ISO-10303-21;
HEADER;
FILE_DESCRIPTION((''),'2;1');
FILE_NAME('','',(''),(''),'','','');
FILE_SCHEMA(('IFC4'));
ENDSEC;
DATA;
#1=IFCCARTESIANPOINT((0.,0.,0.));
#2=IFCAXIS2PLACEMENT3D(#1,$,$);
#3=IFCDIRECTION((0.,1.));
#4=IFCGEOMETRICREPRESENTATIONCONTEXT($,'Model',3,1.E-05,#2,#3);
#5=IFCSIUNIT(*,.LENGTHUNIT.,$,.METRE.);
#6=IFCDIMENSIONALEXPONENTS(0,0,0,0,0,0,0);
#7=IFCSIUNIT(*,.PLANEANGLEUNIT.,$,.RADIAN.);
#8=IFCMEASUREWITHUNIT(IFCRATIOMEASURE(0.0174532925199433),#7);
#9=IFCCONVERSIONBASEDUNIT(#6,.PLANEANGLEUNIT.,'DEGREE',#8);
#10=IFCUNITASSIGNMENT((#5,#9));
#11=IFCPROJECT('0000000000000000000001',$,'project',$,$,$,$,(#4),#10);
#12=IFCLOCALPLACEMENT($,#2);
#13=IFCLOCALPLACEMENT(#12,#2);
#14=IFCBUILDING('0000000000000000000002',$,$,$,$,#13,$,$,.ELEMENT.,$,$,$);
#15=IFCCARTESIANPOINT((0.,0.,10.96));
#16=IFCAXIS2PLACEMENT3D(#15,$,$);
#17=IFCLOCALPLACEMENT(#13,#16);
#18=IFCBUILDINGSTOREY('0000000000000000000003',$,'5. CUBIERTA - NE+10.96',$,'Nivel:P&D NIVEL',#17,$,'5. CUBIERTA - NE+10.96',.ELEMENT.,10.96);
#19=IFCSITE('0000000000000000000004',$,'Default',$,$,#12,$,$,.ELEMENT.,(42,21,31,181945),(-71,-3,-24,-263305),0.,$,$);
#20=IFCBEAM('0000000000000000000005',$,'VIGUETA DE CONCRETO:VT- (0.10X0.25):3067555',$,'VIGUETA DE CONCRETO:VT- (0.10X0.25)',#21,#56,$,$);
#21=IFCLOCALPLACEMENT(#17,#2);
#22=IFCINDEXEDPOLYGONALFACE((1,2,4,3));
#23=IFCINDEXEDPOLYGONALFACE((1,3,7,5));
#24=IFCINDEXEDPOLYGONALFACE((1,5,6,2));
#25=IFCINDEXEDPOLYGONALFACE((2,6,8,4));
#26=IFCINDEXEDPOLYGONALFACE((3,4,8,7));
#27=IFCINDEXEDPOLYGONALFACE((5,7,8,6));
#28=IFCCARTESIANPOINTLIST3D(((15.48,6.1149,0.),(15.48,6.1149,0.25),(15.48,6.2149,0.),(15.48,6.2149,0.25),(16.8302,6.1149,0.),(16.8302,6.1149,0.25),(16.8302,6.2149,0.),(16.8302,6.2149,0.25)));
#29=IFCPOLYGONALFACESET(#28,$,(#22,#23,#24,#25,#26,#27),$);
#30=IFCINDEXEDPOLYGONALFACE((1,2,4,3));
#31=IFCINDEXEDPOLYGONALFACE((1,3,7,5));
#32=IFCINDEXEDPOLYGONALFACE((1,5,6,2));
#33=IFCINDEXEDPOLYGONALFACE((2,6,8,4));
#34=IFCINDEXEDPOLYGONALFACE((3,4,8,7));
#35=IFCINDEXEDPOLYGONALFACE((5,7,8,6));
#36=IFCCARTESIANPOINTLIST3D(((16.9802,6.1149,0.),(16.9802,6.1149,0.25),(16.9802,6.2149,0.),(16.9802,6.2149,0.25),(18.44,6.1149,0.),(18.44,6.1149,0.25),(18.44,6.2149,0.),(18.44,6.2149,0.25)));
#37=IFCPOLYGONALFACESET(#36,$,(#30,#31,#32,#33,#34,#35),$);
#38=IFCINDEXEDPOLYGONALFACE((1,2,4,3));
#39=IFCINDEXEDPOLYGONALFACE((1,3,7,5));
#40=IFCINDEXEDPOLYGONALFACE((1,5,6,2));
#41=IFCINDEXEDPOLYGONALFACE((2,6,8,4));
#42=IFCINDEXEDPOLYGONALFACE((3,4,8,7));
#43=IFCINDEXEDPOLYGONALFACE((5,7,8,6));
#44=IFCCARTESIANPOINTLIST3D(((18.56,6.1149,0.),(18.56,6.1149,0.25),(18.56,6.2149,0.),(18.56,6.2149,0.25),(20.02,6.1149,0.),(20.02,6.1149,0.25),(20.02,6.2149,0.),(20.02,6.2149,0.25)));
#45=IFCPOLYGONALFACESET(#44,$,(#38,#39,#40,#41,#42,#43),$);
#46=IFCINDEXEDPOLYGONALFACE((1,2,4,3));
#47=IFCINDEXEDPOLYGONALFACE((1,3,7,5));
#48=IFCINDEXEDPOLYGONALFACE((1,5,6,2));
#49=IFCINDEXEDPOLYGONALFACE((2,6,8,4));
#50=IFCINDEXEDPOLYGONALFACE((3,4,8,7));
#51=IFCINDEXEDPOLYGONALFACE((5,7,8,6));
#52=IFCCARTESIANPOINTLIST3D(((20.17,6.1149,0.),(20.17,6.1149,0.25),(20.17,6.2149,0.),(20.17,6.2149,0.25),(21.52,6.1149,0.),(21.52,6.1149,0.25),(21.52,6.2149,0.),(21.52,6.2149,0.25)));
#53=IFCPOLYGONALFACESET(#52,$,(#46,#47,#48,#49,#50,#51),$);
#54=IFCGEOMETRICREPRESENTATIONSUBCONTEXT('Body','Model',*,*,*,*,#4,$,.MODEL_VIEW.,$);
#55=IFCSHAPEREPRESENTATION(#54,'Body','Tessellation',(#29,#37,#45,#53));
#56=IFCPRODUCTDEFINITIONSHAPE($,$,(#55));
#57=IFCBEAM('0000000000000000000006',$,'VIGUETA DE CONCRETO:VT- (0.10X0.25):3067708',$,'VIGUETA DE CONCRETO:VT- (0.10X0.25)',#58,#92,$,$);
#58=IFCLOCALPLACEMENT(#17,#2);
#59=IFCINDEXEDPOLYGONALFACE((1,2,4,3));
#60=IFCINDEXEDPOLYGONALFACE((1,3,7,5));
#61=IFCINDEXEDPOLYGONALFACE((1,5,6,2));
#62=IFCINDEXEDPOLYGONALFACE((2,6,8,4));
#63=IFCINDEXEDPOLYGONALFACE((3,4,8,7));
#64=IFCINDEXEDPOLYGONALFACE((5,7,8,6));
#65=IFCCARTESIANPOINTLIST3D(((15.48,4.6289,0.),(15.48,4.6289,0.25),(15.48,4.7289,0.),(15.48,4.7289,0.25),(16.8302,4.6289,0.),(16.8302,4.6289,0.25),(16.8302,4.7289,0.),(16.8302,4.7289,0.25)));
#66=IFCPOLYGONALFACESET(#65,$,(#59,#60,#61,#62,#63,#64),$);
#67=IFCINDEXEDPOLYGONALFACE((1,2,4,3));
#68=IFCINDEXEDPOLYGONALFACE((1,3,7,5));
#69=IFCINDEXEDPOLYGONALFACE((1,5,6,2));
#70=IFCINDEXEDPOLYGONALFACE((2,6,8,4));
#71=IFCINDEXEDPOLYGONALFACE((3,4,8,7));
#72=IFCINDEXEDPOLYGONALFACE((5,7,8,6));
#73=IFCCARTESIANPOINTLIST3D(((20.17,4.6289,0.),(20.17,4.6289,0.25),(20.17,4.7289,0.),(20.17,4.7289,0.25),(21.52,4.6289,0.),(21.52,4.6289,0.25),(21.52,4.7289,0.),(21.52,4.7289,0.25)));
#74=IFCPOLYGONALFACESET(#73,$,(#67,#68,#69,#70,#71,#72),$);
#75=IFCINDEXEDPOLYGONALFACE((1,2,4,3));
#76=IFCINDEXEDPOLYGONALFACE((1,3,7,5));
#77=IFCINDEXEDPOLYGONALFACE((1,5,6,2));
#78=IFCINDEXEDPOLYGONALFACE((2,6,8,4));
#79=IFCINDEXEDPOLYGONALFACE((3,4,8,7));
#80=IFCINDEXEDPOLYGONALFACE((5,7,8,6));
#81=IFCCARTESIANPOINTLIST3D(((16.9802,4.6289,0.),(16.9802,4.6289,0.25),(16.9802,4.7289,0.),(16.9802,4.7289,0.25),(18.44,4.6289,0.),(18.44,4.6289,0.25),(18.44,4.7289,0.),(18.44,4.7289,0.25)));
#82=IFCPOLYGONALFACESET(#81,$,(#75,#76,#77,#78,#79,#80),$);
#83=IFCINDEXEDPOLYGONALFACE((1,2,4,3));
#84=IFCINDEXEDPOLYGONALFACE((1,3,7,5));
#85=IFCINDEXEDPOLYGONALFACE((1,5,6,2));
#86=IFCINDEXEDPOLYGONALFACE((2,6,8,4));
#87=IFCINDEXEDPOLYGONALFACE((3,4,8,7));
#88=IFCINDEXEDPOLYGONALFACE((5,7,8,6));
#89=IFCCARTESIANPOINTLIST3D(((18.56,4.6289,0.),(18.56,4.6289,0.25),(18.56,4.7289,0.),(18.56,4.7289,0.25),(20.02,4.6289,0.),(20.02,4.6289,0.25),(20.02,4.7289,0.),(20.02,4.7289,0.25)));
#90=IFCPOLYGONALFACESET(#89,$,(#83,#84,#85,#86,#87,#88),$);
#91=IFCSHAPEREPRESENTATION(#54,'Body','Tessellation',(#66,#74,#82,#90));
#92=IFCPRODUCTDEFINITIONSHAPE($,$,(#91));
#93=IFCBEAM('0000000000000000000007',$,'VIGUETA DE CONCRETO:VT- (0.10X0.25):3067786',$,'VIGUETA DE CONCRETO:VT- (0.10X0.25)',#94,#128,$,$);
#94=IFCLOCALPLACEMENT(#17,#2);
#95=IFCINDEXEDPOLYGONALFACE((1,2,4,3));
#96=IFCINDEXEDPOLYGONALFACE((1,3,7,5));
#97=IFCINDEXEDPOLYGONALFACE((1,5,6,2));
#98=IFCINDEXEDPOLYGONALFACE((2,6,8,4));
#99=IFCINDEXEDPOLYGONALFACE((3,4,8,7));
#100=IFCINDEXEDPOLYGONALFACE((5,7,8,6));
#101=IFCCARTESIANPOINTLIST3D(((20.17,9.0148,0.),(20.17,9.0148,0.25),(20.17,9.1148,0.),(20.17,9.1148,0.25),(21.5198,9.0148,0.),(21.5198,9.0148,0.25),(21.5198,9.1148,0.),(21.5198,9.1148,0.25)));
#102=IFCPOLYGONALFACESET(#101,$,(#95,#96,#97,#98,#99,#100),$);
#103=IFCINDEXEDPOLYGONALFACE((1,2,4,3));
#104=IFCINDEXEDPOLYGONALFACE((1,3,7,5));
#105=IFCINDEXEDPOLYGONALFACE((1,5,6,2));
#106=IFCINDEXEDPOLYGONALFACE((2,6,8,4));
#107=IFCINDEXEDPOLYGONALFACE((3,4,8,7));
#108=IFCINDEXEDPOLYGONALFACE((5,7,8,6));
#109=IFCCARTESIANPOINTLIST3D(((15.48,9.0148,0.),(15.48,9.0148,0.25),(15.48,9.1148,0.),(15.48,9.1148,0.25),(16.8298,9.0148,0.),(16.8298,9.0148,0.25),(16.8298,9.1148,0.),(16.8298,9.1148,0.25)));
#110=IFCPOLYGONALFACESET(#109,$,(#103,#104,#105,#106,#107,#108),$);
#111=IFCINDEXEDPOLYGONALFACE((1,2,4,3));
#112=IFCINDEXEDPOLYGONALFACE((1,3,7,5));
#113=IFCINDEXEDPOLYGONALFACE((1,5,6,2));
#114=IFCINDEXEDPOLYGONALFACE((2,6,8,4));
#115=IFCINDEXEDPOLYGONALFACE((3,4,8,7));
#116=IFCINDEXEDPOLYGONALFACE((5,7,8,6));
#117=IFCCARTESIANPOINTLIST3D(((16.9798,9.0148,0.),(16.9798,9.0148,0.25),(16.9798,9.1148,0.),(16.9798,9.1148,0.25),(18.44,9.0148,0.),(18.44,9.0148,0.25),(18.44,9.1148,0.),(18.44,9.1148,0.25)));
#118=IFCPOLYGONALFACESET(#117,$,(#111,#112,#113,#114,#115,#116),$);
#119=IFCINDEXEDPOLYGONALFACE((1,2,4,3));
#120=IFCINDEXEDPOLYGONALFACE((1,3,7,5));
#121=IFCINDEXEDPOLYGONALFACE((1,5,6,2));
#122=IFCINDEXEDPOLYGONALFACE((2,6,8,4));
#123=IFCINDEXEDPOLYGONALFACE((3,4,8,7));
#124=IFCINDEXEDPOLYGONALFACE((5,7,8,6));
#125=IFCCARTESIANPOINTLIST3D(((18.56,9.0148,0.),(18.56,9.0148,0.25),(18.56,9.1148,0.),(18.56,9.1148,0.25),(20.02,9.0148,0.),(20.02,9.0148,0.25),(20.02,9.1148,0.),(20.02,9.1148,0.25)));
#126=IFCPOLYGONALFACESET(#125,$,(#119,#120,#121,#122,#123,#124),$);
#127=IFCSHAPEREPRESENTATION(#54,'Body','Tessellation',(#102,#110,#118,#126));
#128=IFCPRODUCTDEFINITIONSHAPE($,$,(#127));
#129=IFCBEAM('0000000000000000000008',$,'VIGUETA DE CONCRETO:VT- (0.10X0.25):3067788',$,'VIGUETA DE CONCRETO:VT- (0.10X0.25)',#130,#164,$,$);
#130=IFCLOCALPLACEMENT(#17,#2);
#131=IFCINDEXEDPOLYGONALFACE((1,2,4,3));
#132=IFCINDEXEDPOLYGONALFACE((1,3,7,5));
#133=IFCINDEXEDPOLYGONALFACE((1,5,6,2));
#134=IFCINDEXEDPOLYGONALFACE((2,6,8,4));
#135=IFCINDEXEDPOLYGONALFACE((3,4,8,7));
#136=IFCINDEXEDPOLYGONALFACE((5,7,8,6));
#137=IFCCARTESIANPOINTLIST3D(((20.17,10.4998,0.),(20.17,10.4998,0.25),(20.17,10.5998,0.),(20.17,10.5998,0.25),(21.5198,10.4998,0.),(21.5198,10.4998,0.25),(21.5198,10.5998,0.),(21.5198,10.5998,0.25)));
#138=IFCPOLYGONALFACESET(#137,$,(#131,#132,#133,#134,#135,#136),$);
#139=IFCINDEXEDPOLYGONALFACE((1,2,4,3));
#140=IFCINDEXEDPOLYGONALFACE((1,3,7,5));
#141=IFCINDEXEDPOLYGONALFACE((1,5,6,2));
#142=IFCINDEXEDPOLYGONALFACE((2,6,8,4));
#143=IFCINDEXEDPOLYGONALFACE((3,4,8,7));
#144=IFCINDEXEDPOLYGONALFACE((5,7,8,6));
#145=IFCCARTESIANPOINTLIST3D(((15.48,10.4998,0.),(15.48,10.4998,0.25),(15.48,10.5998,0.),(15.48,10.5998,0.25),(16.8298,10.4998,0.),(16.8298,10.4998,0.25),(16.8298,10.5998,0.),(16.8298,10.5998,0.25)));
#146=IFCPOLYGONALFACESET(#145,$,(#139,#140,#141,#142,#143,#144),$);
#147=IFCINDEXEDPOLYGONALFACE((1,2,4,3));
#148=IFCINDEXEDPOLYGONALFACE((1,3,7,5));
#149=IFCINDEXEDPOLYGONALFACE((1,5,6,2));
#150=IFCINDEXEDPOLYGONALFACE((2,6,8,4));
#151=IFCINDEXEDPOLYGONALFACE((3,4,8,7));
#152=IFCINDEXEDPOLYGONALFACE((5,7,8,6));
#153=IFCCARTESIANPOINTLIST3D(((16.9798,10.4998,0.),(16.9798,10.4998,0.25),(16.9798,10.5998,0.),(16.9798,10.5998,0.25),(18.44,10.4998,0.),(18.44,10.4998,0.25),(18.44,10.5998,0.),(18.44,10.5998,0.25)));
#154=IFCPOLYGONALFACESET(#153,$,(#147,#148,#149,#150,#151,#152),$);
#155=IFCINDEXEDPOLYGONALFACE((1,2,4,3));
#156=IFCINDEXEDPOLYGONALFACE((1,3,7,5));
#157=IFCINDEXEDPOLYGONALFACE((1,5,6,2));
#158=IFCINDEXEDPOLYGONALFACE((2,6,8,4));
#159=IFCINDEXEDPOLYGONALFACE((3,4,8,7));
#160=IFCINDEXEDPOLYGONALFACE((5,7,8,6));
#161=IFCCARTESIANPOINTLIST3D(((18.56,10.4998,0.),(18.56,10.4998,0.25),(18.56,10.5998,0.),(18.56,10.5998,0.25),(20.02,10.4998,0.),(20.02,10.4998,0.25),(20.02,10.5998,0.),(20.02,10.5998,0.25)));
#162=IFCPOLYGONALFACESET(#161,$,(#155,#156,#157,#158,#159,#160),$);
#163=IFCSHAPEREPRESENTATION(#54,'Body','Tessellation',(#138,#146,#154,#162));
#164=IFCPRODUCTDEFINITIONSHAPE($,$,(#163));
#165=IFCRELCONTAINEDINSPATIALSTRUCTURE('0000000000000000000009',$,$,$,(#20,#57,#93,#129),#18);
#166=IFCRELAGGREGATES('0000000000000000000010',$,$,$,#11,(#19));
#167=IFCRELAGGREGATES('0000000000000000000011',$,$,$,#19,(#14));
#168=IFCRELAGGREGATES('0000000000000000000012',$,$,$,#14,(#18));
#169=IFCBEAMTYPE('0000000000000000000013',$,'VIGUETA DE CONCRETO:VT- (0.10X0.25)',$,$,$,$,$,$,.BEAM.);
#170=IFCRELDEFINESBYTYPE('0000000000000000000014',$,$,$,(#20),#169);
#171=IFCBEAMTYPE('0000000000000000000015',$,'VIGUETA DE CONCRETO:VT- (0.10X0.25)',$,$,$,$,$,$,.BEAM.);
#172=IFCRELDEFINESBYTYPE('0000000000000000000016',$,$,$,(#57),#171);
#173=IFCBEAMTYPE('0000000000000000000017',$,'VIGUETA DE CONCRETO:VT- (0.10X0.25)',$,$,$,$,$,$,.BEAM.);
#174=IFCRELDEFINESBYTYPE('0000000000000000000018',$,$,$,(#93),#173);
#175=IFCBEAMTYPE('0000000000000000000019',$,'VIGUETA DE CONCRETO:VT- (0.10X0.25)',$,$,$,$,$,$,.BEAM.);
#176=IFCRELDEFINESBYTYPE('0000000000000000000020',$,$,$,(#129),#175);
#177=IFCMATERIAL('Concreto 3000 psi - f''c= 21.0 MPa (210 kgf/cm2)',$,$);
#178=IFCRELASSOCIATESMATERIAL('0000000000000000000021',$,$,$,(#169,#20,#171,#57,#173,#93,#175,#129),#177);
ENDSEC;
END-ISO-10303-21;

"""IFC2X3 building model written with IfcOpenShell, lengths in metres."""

from ifc_helpers import new_model, entity, si_unit, converted_unit, direction, frame, frame_2d, origin, place, context, subcontext, project, spatial, rectangle, extrude, source, transform, mapped, material, type_object, type_shapes, element, save


model = new_model("IFC2X3")

# Units and contexts
model_context = context("Model", 3, precision=1e-05, world=origin(), true_north=direction((0.0, 1.0)))
body_context = subcontext(model_context, "Body", "Model", "MODEL_VIEW")
ifc_project = project(units=[si_unit("LENGTHUNIT", "METRE"), converted_unit("PLANEANGLEUNIT", "DEGREE", entity("IfcRatioMeasure", 0.0174532925199433), si_unit("PLANEANGLEUNIT", "RADIAN"), dimensions=[0, 0, 0, 0, 0, 0, 0])], contexts=[model_context])

# Site, building, storey
site_placement = place(None, origin())
site = spatial("IfcSite", under=ifc_project, at=site_placement, Name="Default", CompositionType="ELEMENT", RefLatitude=(42, 21, 31, 181945), RefLongitude=(-71, -3, -24, -263305), RefElevation=0.0)
building_placement = place(site_placement, origin())
building = spatial("IfcBuilding", under=site, at=building_placement, CompositionType="ELEMENT")
storey_placement = place(building_placement, frame((0.0, 0.0, 10.96)))
storey = spatial("IfcBuildingStorey", under=building, at=storey_placement, Name="5. CUBIERTA - NE+10.96", ObjectType="Nivel:P&D NIVEL", LongName="5. CUBIERTA - NE+10.96", CompositionType="ELEMENT", Elevation=10.96)

# Beams
ifc_material_1 = material(Name="Concreto 3000 psi - f'c= 21.0 MPa (210 kgf/cm2)")
beam_type_1 = type_object("IfcBeamType", Name="VIGUETA DE CONCRETO:VT- (0.10X0.25)", PredefinedType="BEAM", material=ifc_material_1)
shared_shape_1 = source(origin(), body_context, "Body", "SweptSolid", [
    extrude(rectangle(XDim=0.25, YDim=0.1, at=frame_2d((0.0, 0.0), x_axis=(1.0, 0.0))), frame((15.48, 6.1649, 11.085), z_axis=(1.0, 0.0, 0.0), x_axis=(0.0, 0.0, -1.0)), (0.0, 0.0, 1.0), 1.3502),
    extrude(rectangle(XDim=0.25, YDim=0.1, at=frame_2d((0.0, 0.0), x_axis=(1.0, 0.0))), frame((16.9802, 6.1649, 11.085), z_axis=(1.0, 0.0, 0.0), x_axis=(0.0, 0.0, -1.0)), (0.0, 0.0, 1.0), 1.4598),
    extrude(rectangle(XDim=0.25, YDim=0.1, at=frame_2d((0.0, 0.0), x_axis=(1.0, 0.0))), frame((18.56, 6.1649, 11.085), z_axis=(1.0, 0.0, 0.0), x_axis=(0.0, 0.0, -1.0)), (0.0, 0.0, 1.0), 1.46),
    extrude(rectangle(XDim=0.25, YDim=0.1, at=frame_2d((0.0, 0.0), x_axis=(1.0, 0.0))), frame((20.17, 6.1649, 11.085), z_axis=(1.0, 0.0, 0.0), x_axis=(0.0, 0.0, -1.0)), (0.0, 0.0, 1.0), 1.35),
])
type_shapes(beam_type_1, [shared_shape_1])
beam_1_placement = place(storey_placement, frame((0.0, 0.0, -10.96)))
element("IfcBeam", 1, at=beam_1_placement, inside=storey, type_object=beam_type_1, material=ifc_material_1, Name="VIGUETA DE CONCRETO:VT- (0.10X0.25):3067555", ObjectType="VIGUETA DE CONCRETO:VT- (0.10X0.25)", context=body_context, shape_type="MappedRepresentation", body=[
    mapped(shared_shape_1, transform((0.0, 0.0, 0.0), scale=1.0)),
])
beam_type_2 = type_object("IfcBeamType", Name="VIGUETA DE CONCRETO:VT- (0.10X0.25)", PredefinedType="BEAM", material=ifc_material_1)
shared_shape_2 = source(origin(), body_context, "Body", "SweptSolid", [
    extrude(rectangle(XDim=0.25, YDim=0.1, at=frame_2d((0.0, 0.0), x_axis=(1.0, 0.0))), frame((15.48, 4.6789, 11.085), z_axis=(1.0, 0.0, 0.0), x_axis=(0.0, 0.0, -1.0)), (0.0, 0.0, 1.0), 1.3502),
    extrude(rectangle(XDim=0.25, YDim=0.1, at=frame_2d((0.0, 0.0), x_axis=(1.0, 0.0))), frame((20.17, 4.6789, 11.085), z_axis=(1.0, 0.0, 0.0), x_axis=(0.0, 0.0, -1.0)), (0.0, 0.0, 1.0), 1.35),
    extrude(rectangle(XDim=0.25, YDim=0.1, at=frame_2d((0.0, 0.0), x_axis=(1.0, 0.0))), frame((16.9802, 4.6789, 11.085), z_axis=(1.0, 0.0, 0.0), x_axis=(0.0, 0.0, -1.0)), (0.0, 0.0, 1.0), 1.4598),
    extrude(rectangle(XDim=0.25, YDim=0.1, at=frame_2d((0.0, 0.0), x_axis=(1.0, 0.0))), frame((18.56, 4.6789, 11.085), z_axis=(1.0, 0.0, 0.0), x_axis=(0.0, 0.0, -1.0)), (0.0, 0.0, 1.0), 1.46),
])
type_shapes(beam_type_2, [shared_shape_2])
beam_2_placement = place(storey_placement, frame((0.0, 0.0, -10.96)))
element("IfcBeam", 2, at=beam_2_placement, inside=storey, type_object=beam_type_2, material=ifc_material_1, Name="VIGUETA DE CONCRETO:VT- (0.10X0.25):3067708", ObjectType="VIGUETA DE CONCRETO:VT- (0.10X0.25)", context=body_context, shape_type="MappedRepresentation", body=[
    mapped(shared_shape_2, transform((0.0, 0.0, 0.0), scale=1.0)),
])
beam_type_3 = type_object("IfcBeamType", Name="VIGUETA DE CONCRETO:VT- (0.10X0.25)", PredefinedType="BEAM", material=ifc_material_1)
shared_shape_3 = source(origin(), body_context, "Body", "SweptSolid", [
    extrude(rectangle(XDim=0.25, YDim=0.1, at=frame_2d((0.0, 0.0), x_axis=(1.0, 0.0))), frame((20.17, 9.0648, 11.085), z_axis=(1.0, 0.0, 0.0), x_axis=(0.0, 0.0, -1.0)), (0.0, 0.0, 1.0), 1.3498),
    extrude(rectangle(XDim=0.25, YDim=0.1, at=frame_2d((0.0, 0.0), x_axis=(1.0, 0.0))), frame((15.48, 9.0648, 11.085), z_axis=(1.0, 0.0, 0.0), x_axis=(0.0, 0.0, -1.0)), (0.0, 0.0, 1.0), 1.3498),
    extrude(rectangle(XDim=0.25, YDim=0.1, at=frame_2d((0.0, 0.0), x_axis=(1.0, 0.0))), frame((16.9798, 9.0648, 11.085), z_axis=(1.0, 0.0, 0.0), x_axis=(0.0, 0.0, -1.0)), (0.0, 0.0, 1.0), 1.4602),
    extrude(rectangle(XDim=0.25, YDim=0.1, at=frame_2d((0.0, 0.0), x_axis=(1.0, 0.0))), frame((18.56, 9.0648, 11.085), z_axis=(1.0, 0.0, 0.0), x_axis=(0.0, 0.0, -1.0)), (0.0, 0.0, 1.0), 1.46),
])
type_shapes(beam_type_3, [shared_shape_3])
beam_3_placement = place(storey_placement, frame((0.0, 0.0, -10.96)))
element("IfcBeam", 3, at=beam_3_placement, inside=storey, type_object=beam_type_3, material=ifc_material_1, Name="VIGUETA DE CONCRETO:VT- (0.10X0.25):3067786", ObjectType="VIGUETA DE CONCRETO:VT- (0.10X0.25)", context=body_context, shape_type="MappedRepresentation", body=[
    mapped(shared_shape_3, transform((0.0, 0.0, 0.0), scale=1.0)),
])
beam_type_4 = type_object("IfcBeamType", Name="VIGUETA DE CONCRETO:VT- (0.10X0.25)", PredefinedType="BEAM", material=ifc_material_1)
shared_shape_4 = source(origin(), body_context, "Body", "SweptSolid", [
    extrude(rectangle(XDim=0.25, YDim=0.1, at=frame_2d((0.0, 0.0), x_axis=(1.0, 0.0))), frame((20.17, 10.5498, 11.085), z_axis=(1.0, 0.0, 0.0), x_axis=(0.0, 0.0, -1.0)), (0.0, 0.0, 1.0), 1.3498),
    extrude(rectangle(XDim=0.25, YDim=0.1, at=frame_2d((0.0, 0.0), x_axis=(1.0, 0.0))), frame((15.48, 10.5498, 11.085), z_axis=(1.0, 0.0, 0.0), x_axis=(0.0, 0.0, -1.0)), (0.0, 0.0, 1.0), 1.3498),
    extrude(rectangle(XDim=0.25, YDim=0.1, at=frame_2d((0.0, 0.0), x_axis=(1.0, 0.0))), frame((16.9798, 10.5498, 11.085), z_axis=(1.0, 0.0, 0.0), x_axis=(0.0, 0.0, -1.0)), (0.0, 0.0, 1.0), 1.4602),
    extrude(rectangle(XDim=0.25, YDim=0.1, at=frame_2d((0.0, 0.0), x_axis=(1.0, 0.0))), frame((18.56, 10.5498, 11.085), z_axis=(1.0, 0.0, 0.0), x_axis=(0.0, 0.0, -1.0)), (0.0, 0.0, 1.0), 1.46),
])
type_shapes(beam_type_4, [shared_shape_4])
beam_4_placement = place(storey_placement, frame((0.0, 0.0, -10.96)))
element("IfcBeam", 4, at=beam_4_placement, inside=storey, type_object=beam_type_4, material=ifc_material_1, Name="VIGUETA DE CONCRETO:VT- (0.10X0.25):3067788", ObjectType="VIGUETA DE CONCRETO:VT- (0.10X0.25)", context=body_context, shape_type="MappedRepresentation", body=[
    mapped(shared_shape_4, transform((0.0, 0.0, 0.0), scale=1.0)),
])

save(model, "model.ifc")
